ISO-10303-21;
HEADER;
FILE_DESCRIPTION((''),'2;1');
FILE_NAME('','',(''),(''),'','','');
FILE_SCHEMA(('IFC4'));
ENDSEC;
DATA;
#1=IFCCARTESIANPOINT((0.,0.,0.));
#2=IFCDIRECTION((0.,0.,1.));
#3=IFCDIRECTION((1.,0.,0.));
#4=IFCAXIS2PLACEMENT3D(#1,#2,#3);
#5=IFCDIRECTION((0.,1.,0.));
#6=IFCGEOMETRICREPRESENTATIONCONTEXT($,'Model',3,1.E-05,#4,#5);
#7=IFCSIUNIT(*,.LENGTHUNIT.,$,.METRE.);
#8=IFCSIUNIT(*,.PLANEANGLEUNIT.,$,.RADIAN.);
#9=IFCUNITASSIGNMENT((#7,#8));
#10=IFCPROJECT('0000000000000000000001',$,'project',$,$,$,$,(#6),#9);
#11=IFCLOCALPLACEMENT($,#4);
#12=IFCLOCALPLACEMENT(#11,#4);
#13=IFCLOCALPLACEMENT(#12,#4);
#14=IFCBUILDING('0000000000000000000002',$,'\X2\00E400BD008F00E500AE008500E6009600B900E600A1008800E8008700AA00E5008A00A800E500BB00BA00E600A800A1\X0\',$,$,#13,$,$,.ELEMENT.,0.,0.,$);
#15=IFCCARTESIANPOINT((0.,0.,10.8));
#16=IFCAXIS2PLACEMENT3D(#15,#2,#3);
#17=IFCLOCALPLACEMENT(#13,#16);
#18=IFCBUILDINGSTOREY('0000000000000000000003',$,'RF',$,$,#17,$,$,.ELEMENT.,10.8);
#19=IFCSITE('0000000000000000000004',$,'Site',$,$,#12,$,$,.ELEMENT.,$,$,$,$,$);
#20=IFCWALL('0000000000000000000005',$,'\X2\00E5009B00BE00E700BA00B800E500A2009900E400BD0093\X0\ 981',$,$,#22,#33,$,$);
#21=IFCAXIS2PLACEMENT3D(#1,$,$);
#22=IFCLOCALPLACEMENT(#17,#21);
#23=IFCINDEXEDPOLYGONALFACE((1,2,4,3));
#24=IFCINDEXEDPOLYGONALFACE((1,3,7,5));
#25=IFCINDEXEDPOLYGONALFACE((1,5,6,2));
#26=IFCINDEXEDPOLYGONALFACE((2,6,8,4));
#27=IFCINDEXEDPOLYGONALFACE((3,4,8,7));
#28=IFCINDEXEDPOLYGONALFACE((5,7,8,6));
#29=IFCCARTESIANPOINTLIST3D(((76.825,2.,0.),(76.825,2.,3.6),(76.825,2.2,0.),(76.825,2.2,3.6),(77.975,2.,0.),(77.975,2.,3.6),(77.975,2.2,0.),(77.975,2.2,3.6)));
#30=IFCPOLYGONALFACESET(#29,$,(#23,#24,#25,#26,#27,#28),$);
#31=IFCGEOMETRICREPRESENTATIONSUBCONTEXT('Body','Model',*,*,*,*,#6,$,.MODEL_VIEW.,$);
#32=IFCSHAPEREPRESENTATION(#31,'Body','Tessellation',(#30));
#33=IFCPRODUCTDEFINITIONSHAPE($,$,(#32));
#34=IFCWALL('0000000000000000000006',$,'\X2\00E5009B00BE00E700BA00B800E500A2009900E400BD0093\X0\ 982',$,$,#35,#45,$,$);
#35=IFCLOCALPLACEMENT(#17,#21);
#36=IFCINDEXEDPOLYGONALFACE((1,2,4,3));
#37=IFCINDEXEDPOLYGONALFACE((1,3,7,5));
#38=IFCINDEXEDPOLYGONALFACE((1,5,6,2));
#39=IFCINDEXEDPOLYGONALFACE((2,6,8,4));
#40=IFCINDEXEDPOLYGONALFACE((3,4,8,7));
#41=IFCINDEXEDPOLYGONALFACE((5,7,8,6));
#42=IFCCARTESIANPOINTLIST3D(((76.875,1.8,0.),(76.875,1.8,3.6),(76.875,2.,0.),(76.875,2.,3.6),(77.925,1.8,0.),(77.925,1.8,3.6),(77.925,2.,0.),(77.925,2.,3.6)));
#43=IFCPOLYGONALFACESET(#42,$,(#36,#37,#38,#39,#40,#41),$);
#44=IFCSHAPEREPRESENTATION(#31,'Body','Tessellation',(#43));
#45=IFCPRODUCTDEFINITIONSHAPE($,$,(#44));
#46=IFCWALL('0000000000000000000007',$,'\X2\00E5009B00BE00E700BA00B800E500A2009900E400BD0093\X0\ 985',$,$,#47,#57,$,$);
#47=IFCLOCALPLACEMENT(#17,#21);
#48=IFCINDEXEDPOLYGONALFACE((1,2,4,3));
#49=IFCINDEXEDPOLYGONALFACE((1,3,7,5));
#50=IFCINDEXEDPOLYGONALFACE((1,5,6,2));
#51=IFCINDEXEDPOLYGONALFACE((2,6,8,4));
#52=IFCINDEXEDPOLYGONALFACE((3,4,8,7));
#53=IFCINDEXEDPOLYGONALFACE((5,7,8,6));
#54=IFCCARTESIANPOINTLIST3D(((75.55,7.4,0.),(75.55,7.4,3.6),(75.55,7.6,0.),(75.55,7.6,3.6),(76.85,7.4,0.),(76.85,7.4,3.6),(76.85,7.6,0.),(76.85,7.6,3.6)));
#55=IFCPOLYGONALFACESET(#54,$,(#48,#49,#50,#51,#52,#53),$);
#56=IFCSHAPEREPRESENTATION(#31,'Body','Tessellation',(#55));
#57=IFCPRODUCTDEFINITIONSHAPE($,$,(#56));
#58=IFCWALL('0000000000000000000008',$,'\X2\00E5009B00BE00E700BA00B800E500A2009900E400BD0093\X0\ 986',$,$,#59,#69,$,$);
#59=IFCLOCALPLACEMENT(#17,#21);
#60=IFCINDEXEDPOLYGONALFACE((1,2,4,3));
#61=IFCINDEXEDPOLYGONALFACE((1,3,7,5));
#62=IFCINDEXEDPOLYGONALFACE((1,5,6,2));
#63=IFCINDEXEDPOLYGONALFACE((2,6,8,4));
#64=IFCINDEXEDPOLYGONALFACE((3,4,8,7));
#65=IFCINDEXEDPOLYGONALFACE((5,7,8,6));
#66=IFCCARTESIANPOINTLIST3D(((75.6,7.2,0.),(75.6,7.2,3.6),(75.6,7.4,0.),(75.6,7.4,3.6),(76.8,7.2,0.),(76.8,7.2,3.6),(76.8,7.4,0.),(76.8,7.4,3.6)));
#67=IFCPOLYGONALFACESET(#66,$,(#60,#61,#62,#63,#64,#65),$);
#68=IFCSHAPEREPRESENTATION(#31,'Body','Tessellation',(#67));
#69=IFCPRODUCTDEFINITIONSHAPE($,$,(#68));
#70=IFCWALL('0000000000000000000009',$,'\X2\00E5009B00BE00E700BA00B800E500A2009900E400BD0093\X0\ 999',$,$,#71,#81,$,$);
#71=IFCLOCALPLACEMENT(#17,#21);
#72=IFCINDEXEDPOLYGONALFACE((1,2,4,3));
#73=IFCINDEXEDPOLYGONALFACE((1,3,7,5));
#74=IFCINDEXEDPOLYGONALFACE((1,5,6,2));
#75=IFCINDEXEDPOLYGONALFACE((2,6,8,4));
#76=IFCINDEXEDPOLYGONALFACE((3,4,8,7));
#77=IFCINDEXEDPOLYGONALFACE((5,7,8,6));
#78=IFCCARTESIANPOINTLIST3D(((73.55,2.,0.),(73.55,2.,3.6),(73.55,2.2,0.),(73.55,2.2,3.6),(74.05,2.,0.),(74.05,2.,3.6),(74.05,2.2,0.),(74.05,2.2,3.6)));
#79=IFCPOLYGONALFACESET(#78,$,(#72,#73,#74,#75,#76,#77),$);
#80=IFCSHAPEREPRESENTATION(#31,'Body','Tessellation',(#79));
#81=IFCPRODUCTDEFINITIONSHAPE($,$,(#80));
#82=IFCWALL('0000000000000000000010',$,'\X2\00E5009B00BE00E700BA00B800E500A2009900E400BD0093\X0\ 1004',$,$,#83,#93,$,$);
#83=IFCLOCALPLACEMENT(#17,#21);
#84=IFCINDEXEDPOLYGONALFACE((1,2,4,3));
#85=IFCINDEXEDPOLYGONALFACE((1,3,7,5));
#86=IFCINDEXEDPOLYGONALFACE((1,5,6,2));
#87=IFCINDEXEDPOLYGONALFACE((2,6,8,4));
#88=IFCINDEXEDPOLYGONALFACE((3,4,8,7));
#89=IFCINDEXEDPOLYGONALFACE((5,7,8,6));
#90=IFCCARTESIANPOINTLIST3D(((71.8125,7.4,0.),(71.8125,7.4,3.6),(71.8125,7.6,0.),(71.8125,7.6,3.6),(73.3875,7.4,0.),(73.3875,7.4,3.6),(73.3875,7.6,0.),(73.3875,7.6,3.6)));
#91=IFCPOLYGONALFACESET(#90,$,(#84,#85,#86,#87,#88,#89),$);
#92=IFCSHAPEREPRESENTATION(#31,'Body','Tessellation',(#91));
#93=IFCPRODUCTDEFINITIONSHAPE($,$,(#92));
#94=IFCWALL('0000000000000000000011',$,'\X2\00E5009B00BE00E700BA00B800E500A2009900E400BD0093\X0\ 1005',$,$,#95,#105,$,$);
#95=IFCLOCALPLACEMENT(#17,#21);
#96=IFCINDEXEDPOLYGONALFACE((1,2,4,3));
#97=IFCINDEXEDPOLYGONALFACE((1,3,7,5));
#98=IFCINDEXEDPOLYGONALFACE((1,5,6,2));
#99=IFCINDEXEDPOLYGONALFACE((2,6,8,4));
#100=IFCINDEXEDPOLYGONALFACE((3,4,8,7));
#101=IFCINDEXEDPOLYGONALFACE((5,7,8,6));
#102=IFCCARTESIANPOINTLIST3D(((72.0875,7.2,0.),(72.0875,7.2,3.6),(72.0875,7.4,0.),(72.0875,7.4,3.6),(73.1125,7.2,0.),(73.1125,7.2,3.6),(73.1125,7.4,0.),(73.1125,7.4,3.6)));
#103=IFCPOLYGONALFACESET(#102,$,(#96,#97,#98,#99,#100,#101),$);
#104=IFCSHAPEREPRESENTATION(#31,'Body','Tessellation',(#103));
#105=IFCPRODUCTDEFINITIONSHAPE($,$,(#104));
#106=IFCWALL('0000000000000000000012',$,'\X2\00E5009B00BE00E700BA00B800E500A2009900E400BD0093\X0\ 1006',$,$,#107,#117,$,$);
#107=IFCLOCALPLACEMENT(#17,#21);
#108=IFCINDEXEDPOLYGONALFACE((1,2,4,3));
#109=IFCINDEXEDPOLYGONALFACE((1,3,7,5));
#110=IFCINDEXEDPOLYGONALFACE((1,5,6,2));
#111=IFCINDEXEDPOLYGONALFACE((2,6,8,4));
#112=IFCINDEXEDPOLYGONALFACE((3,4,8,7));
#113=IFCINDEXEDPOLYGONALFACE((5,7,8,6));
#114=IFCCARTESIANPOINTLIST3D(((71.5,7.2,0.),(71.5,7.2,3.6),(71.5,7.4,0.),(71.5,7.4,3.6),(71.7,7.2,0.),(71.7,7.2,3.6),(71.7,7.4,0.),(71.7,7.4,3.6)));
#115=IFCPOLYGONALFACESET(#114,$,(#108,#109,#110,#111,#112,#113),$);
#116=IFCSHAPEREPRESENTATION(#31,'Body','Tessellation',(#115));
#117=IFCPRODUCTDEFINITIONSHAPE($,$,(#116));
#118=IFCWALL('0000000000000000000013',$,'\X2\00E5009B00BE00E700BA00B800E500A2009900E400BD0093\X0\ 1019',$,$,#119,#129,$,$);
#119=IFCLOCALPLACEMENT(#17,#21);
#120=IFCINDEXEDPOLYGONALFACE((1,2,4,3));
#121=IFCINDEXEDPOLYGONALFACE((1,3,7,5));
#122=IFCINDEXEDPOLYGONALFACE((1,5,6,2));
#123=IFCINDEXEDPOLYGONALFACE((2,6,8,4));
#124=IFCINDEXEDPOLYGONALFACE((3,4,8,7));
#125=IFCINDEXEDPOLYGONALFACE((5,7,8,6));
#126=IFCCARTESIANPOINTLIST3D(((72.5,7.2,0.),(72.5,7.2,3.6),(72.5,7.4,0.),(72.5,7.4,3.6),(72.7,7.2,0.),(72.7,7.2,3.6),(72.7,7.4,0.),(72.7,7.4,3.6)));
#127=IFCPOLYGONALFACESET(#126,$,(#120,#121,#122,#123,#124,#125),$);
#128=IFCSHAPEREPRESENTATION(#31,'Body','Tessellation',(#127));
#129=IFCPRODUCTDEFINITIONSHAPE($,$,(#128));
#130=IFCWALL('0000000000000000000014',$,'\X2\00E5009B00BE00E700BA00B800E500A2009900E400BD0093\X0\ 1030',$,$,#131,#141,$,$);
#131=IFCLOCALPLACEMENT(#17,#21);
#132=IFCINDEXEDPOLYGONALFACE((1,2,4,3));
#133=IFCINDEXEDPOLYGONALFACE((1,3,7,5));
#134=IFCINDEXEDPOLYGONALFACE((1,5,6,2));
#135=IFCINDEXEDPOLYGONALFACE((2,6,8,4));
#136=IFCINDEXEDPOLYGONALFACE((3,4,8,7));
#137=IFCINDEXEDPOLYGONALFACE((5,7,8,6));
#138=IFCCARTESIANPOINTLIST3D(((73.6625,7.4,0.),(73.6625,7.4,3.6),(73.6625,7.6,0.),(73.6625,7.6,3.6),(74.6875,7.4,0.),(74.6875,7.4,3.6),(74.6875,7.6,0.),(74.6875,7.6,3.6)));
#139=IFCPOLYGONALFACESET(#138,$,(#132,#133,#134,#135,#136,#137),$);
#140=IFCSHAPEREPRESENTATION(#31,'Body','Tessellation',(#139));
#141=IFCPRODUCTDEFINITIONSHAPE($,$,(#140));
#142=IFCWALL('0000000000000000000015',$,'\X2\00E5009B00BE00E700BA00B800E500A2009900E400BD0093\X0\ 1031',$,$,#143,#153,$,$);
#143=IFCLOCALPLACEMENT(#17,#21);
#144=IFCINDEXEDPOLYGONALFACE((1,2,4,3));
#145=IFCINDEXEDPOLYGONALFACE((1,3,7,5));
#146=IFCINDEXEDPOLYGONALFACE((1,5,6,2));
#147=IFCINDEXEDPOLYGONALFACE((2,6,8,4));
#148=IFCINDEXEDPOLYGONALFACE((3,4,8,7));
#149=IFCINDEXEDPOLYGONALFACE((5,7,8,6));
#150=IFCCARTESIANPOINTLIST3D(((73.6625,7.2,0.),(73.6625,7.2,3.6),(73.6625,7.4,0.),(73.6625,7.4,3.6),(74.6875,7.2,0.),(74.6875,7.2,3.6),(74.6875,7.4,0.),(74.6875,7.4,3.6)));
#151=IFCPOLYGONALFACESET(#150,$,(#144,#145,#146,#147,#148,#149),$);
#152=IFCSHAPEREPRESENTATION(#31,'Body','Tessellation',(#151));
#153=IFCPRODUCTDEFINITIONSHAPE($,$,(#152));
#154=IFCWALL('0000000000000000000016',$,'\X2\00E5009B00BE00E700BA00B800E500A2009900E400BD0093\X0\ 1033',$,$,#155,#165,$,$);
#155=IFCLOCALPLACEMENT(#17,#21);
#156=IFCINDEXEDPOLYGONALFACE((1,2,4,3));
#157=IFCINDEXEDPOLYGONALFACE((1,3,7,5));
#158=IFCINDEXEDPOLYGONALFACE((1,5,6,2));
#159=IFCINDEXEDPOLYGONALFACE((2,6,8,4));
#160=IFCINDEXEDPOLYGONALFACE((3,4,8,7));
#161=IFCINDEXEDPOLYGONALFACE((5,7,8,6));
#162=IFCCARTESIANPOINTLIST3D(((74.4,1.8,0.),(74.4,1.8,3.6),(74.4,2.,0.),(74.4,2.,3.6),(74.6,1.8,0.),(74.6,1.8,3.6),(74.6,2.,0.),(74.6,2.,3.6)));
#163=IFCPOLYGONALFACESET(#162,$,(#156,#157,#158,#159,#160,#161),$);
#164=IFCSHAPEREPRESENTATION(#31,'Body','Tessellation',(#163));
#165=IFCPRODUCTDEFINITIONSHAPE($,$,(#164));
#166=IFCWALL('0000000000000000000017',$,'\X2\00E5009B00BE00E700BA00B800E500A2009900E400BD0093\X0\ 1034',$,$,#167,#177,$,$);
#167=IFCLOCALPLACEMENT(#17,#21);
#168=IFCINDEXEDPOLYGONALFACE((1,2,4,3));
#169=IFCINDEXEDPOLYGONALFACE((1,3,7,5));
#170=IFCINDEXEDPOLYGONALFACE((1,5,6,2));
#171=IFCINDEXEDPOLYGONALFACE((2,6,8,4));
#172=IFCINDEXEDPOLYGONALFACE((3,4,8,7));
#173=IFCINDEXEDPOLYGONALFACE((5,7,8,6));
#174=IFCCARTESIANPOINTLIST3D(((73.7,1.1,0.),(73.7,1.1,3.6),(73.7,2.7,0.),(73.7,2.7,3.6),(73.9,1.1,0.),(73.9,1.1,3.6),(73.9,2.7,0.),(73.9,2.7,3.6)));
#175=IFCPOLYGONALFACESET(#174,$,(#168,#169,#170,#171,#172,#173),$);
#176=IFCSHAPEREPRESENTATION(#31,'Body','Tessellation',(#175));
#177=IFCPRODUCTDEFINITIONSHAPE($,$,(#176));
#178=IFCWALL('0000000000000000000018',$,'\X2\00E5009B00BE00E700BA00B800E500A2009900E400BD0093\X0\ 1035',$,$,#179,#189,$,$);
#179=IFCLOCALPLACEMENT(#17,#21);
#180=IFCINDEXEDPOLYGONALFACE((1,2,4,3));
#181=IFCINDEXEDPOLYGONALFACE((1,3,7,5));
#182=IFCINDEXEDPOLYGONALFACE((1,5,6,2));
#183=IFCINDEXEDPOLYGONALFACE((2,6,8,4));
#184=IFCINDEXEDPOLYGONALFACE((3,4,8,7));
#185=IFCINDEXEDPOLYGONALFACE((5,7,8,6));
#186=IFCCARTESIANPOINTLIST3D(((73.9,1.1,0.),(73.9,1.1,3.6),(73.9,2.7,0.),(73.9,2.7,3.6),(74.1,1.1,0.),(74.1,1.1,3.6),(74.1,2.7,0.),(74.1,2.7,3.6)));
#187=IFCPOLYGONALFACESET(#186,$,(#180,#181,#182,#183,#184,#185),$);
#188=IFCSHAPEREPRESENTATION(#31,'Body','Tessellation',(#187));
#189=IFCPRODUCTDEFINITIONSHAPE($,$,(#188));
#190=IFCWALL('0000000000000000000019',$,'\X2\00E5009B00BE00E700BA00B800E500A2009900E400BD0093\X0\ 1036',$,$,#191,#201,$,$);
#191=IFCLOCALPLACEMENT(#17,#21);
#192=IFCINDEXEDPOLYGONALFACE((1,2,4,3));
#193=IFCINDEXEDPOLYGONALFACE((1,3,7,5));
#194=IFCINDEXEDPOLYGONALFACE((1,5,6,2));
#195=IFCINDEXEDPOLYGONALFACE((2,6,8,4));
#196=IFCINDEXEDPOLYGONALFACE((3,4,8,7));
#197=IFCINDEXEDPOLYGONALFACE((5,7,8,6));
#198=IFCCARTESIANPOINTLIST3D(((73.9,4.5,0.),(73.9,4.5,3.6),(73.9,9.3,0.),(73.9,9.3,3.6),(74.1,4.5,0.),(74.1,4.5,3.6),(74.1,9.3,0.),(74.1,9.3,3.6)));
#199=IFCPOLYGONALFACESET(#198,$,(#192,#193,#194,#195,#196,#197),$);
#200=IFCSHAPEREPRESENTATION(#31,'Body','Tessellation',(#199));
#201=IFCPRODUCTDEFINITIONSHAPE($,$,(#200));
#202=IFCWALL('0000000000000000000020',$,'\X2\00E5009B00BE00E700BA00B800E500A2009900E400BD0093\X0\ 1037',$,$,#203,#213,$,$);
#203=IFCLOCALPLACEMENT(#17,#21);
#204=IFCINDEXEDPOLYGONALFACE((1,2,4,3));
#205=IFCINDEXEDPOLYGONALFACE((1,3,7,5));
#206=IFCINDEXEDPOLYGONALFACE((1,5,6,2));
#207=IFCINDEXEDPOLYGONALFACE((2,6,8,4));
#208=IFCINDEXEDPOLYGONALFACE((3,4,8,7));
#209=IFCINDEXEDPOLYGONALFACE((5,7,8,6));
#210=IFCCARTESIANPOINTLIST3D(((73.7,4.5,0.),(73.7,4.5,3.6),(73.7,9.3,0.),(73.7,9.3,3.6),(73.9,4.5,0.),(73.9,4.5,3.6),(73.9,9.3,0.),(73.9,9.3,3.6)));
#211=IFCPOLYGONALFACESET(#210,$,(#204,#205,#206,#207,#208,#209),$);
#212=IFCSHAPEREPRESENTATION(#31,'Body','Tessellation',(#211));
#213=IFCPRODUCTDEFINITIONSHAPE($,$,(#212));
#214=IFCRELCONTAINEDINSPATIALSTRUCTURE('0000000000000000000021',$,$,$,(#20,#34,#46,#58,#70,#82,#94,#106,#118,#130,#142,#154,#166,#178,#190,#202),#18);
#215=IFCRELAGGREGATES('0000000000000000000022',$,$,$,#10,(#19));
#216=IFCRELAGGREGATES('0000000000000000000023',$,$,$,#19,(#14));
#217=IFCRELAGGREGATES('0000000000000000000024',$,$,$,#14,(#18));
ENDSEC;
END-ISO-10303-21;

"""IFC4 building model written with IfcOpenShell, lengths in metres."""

from ifc_helpers import new_model, si_unit, direction, frame, frame_2d, origin_with_axes, place, context, subcontext, project, spatial, rectangle, extrude, element, save


model = new_model("IFC4")

# Units and contexts
model_context = context("Model", 3, precision=1e-05, world=origin_with_axes(), true_north=direction((0.0, 1.0, 0.0)))
body_context = subcontext(model_context, "Body", "Model", "MODEL_VIEW")
ifc_project = project(units=[si_unit("LENGTHUNIT", "METRE"), si_unit("PLANEANGLEUNIT", "RADIAN")], contexts=[model_context])

# Site, building, storey
placement = place(None, origin_with_axes())
site_placement = place(placement, origin_with_axes())
site = spatial("IfcSite", under=ifc_project, at=site_placement, Name="Site", CompositionType="ELEMENT")
building_placement = place(site_placement, origin_with_axes())
building = spatial("IfcBuilding", under=site, at=building_placement, Name="ä½\u008få®\u0085æ\u0096¹æ¡\u0088è\u0087ªå\u008a¨å»ºæ¨¡", CompositionType="ELEMENT", ElevationOfRefHeight=0.0, ElevationOfTerrain=0.0)
storey_placement = place(building_placement, frame((0.0, 0.0, 10.8), z_axis=(0.0, 0.0, 1.0), x_axis=(1.0, 0.0, 0.0)))
storey = spatial("IfcBuildingStorey", under=building, at=storey_placement, Name="RF", CompositionType="ELEMENT", Elevation=10.8)

# Walls
wall_1_placement = place(storey_placement, frame((77.4, 2.1, 0.0), z_axis=(0.0, 0.0, 1.0), x_axis=(-1.0, 0.0, 0.0)))
element("IfcWall", 1, at=wall_1_placement, inside=storey, Name="å\u009b¾çº¸å¢\u0099ä½\u0093 981", context=body_context, shape_type="SweptSolid", body=[
    extrude(rectangle(XDim=1.15, YDim=0.2, at=frame_2d((0.0, 0.0), x_axis=(1.0, 0.0, 0.0))), frame((0.0, 0.0, 0.0), z_axis=(0.0, 0.0, 1.0)), (0.0, 0.0, 1.0), 3.6),
])
wall_2_placement = place(storey_placement, frame((77.4, 1.9, 0.0), z_axis=(0.0, 0.0, 1.0), x_axis=(-1.0, 0.0, 0.0)))
element("IfcWall", 2, at=wall_2_placement, inside=storey, Name="å\u009b¾çº¸å¢\u0099ä½\u0093 982", context=body_context, shape_type="SweptSolid", body=[
    extrude(rectangle(XDim=1.05, YDim=0.2, at=frame_2d((0.0, 0.0), x_axis=(1.0, 0.0, 0.0))), frame((0.0, 0.0, 0.0), z_axis=(0.0, 0.0, 1.0)), (0.0, 0.0, 1.0), 3.6),
])
wall_3_placement = place(storey_placement, frame((76.2, 7.5, 0.0), z_axis=(0.0, 0.0, 1.0), x_axis=(1.0, 0.0, 0.0)))
element("IfcWall", 3, at=wall_3_placement, inside=storey, Name="å\u009b¾çº¸å¢\u0099ä½\u0093 985", context=body_context, shape_type="SweptSolid", body=[
    extrude(rectangle(XDim=1.3, YDim=0.2, at=frame_2d((0.0, 0.0), x_axis=(1.0, 0.0, 0.0))), frame((0.0, 0.0, 0.0), z_axis=(0.0, 0.0, 1.0)), (0.0, 0.0, 1.0), 3.6),
])
wall_4_placement = place(storey_placement, frame((76.2, 7.3, 0.0), z_axis=(0.0, 0.0, 1.0), x_axis=(1.0, 0.0, 0.0)))
element("IfcWall", 4, at=wall_4_placement, inside=storey, Name="å\u009b¾çº¸å¢\u0099ä½\u0093 986", context=body_context, shape_type="SweptSolid", body=[
    extrude(rectangle(XDim=1.2, YDim=0.2, at=frame_2d((0.0, 0.0), x_axis=(1.0, 0.0, 0.0))), frame((0.0, 0.0, 0.0), z_axis=(0.0, 0.0, 1.0)), (0.0, 0.0, 1.0), 3.6),
])
wall_5_placement = place(storey_placement, frame((73.8, 2.1, 0.0), z_axis=(0.0, 0.0, 1.0), x_axis=(-1.0, 0.0, 0.0)))
element("IfcWall", 5, at=wall_5_placement, inside=storey, Name="å\u009b¾çº¸å¢\u0099ä½\u0093 999", context=body_context, shape_type="SweptSolid", body=[
    extrude(rectangle(XDim=0.5, YDim=0.2, at=frame_2d((0.0, 0.0), x_axis=(1.0, 0.0, 0.0))), frame((0.0, 0.0, 0.0), z_axis=(0.0, 0.0, 1.0)), (0.0, 0.0, 1.0), 3.6),
])
wall_6_placement = place(storey_placement, frame((72.6, 7.5, 0.0), z_axis=(0.0, 0.0, 1.0), x_axis=(1.0, 0.0, 0.0)))
element("IfcWall", 6, at=wall_6_placement, inside=storey, Name="å\u009b¾çº¸å¢\u0099ä½\u0093 1004", context=body_context, shape_type="SweptSolid", body=[
    extrude(rectangle(XDim=1.575, YDim=0.2, at=frame_2d((0.0, 0.0), x_axis=(1.0, 0.0, 0.0))), frame((0.0, 0.0, 0.0), z_axis=(0.0, 0.0, 1.0)), (0.0, 0.0, 1.0), 3.6),
])
wall_7_placement = place(storey_placement, frame((72.6, 7.3, 0.0), z_axis=(0.0, 0.0, 1.0), x_axis=(1.0, 0.0, 0.0)))
element("IfcWall", 7, at=wall_7_placement, inside=storey, Name="å\u009b¾çº¸å¢\u0099ä½\u0093 1005", context=body_context, shape_type="SweptSolid", body=[
    extrude(rectangle(XDim=1.025, YDim=0.2, at=frame_2d((0.0, 0.0), x_axis=(1.0, 0.0, 0.0))), frame((0.0, 0.0, 0.0), z_axis=(0.0, 0.0, 1.0)), (0.0, 0.0, 1.0), 3.6),
])
for number, where, z_axis, x_axis, name in (
    (8, (71.6, 7.3, 0.0), (0.0, 0.0, 1.0), (0.0, 1.0, 0.0), "å\u009b¾çº¸å¢\u0099ä½\u0093 1006"),
    (9, (72.6, 7.3, 0.0), (0.0, 0.0, 1.0), (0.0, 1.0, 0.0), "å\u009b¾çº¸å¢\u0099ä½\u0093 1019"),
):
    element("IfcWall", number, at=place(storey_placement, frame(where, z_axis=z_axis, x_axis=x_axis)), inside=storey, Name=name, context=body_context, shape_type="SweptSolid", body=[
        extrude(rectangle(XDim=0.2, YDim=0.2, at=frame_2d((0.0, 0.0), x_axis=(1.0, 0.0, 0.0))), frame((0.0, 0.0, 0.0), z_axis=(0.0, 0.0, 1.0)), (0.0, 0.0, 1.0), 3.6),
    ])
for number, where, z_axis, x_axis, name in (
    (10, (74.175, 7.5, 0.0), (0.0, 0.0, 1.0), (1.0, 0.0, 0.0), "å\u009b¾çº¸å¢\u0099ä½\u0093 1030"),
    (11, (74.175, 7.3, 0.0), (0.0, 0.0, 1.0), (1.0, 0.0, 0.0), "å\u009b¾çº¸å¢\u0099ä½\u0093 1031"),
):
    element("IfcWall", number, at=place(storey_placement, frame(where, z_axis=z_axis, x_axis=x_axis)), inside=storey, Name=name, context=body_context, shape_type="SweptSolid", body=[
        extrude(rectangle(XDim=1.025, YDim=0.2, at=frame_2d((0.0, 0.0), x_axis=(1.0, 0.0, 0.0))), frame((0.0, 0.0, 0.0), z_axis=(0.0, 0.0, 1.0)), (0.0, 0.0, 1.0), 3.6),
    ])
wall_8_placement = place(storey_placement, frame((74.5, 1.9, 0.0), z_axis=(0.0, 0.0, 1.0), x_axis=(0.0, 1.0, 0.0)))
element("IfcWall", 12, at=wall_8_placement, inside=storey, Name="å\u009b¾çº¸å¢\u0099ä½\u0093 1033", context=body_context, shape_type="SweptSolid", body=[
    extrude(rectangle(XDim=0.2, YDim=0.2, at=frame_2d((0.0, 0.0), x_axis=(1.0, 0.0, 0.0))), frame((0.0, 0.0, 0.0), z_axis=(0.0, 0.0, 1.0)), (0.0, 0.0, 1.0), 3.6),
])
for number, where, z_axis, x_axis, name in (
    (13, (73.8, 1.9, 0.0), (0.0, 0.0, 1.0), (0.0, -1.0, 0.0), "å\u009b¾çº¸å¢\u0099ä½\u0093 1034"),
    (14, (74.0, 1.9, 0.0), (0.0, 0.0, 1.0), (0.0, -1.0, 0.0), "å\u009b¾çº¸å¢\u0099ä½\u0093 1035"),
):
    element("IfcWall", number, at=place(storey_placement, frame(where, z_axis=z_axis, x_axis=x_axis)), inside=storey, Name=name, context=body_context, shape_type="SweptSolid", body=[
        extrude(rectangle(XDim=1.6, YDim=0.2, at=frame_2d((0.0, 0.0), x_axis=(1.0, 0.0, 0.0))), frame((0.0, 0.0, 0.0), z_axis=(0.0, 0.0, 1.0)), (0.0, 0.0, 1.0), 3.6),
    ])
for number, where, z_axis, x_axis, name in (
    (15, (74.0, 6.9, 0.0), (0.0, 0.0, 1.0), (0.0, -1.0, 0.0), "å\u009b¾çº¸å¢\u0099ä½\u0093 1036"),
    (16, (73.8, 6.9, 0.0), (0.0, 0.0, 1.0), (0.0, -1.0, 0.0), "å\u009b¾çº¸å¢\u0099ä½\u0093 1037"),
):
    element("IfcWall", number, at=place(storey_placement, frame(where, z_axis=z_axis, x_axis=x_axis)), inside=storey, Name=name, context=body_context, shape_type="SweptSolid", body=[
        extrude(rectangle(XDim=4.8, YDim=0.2, at=frame_2d((0.0, 0.0), x_axis=(1.0, 0.0, 0.0))), frame((0.0, 0.0, 0.0), z_axis=(0.0, 0.0, 1.0)), (0.0, 0.0, 1.0), 3.6),
    ])

save(model, "model.ifc")
